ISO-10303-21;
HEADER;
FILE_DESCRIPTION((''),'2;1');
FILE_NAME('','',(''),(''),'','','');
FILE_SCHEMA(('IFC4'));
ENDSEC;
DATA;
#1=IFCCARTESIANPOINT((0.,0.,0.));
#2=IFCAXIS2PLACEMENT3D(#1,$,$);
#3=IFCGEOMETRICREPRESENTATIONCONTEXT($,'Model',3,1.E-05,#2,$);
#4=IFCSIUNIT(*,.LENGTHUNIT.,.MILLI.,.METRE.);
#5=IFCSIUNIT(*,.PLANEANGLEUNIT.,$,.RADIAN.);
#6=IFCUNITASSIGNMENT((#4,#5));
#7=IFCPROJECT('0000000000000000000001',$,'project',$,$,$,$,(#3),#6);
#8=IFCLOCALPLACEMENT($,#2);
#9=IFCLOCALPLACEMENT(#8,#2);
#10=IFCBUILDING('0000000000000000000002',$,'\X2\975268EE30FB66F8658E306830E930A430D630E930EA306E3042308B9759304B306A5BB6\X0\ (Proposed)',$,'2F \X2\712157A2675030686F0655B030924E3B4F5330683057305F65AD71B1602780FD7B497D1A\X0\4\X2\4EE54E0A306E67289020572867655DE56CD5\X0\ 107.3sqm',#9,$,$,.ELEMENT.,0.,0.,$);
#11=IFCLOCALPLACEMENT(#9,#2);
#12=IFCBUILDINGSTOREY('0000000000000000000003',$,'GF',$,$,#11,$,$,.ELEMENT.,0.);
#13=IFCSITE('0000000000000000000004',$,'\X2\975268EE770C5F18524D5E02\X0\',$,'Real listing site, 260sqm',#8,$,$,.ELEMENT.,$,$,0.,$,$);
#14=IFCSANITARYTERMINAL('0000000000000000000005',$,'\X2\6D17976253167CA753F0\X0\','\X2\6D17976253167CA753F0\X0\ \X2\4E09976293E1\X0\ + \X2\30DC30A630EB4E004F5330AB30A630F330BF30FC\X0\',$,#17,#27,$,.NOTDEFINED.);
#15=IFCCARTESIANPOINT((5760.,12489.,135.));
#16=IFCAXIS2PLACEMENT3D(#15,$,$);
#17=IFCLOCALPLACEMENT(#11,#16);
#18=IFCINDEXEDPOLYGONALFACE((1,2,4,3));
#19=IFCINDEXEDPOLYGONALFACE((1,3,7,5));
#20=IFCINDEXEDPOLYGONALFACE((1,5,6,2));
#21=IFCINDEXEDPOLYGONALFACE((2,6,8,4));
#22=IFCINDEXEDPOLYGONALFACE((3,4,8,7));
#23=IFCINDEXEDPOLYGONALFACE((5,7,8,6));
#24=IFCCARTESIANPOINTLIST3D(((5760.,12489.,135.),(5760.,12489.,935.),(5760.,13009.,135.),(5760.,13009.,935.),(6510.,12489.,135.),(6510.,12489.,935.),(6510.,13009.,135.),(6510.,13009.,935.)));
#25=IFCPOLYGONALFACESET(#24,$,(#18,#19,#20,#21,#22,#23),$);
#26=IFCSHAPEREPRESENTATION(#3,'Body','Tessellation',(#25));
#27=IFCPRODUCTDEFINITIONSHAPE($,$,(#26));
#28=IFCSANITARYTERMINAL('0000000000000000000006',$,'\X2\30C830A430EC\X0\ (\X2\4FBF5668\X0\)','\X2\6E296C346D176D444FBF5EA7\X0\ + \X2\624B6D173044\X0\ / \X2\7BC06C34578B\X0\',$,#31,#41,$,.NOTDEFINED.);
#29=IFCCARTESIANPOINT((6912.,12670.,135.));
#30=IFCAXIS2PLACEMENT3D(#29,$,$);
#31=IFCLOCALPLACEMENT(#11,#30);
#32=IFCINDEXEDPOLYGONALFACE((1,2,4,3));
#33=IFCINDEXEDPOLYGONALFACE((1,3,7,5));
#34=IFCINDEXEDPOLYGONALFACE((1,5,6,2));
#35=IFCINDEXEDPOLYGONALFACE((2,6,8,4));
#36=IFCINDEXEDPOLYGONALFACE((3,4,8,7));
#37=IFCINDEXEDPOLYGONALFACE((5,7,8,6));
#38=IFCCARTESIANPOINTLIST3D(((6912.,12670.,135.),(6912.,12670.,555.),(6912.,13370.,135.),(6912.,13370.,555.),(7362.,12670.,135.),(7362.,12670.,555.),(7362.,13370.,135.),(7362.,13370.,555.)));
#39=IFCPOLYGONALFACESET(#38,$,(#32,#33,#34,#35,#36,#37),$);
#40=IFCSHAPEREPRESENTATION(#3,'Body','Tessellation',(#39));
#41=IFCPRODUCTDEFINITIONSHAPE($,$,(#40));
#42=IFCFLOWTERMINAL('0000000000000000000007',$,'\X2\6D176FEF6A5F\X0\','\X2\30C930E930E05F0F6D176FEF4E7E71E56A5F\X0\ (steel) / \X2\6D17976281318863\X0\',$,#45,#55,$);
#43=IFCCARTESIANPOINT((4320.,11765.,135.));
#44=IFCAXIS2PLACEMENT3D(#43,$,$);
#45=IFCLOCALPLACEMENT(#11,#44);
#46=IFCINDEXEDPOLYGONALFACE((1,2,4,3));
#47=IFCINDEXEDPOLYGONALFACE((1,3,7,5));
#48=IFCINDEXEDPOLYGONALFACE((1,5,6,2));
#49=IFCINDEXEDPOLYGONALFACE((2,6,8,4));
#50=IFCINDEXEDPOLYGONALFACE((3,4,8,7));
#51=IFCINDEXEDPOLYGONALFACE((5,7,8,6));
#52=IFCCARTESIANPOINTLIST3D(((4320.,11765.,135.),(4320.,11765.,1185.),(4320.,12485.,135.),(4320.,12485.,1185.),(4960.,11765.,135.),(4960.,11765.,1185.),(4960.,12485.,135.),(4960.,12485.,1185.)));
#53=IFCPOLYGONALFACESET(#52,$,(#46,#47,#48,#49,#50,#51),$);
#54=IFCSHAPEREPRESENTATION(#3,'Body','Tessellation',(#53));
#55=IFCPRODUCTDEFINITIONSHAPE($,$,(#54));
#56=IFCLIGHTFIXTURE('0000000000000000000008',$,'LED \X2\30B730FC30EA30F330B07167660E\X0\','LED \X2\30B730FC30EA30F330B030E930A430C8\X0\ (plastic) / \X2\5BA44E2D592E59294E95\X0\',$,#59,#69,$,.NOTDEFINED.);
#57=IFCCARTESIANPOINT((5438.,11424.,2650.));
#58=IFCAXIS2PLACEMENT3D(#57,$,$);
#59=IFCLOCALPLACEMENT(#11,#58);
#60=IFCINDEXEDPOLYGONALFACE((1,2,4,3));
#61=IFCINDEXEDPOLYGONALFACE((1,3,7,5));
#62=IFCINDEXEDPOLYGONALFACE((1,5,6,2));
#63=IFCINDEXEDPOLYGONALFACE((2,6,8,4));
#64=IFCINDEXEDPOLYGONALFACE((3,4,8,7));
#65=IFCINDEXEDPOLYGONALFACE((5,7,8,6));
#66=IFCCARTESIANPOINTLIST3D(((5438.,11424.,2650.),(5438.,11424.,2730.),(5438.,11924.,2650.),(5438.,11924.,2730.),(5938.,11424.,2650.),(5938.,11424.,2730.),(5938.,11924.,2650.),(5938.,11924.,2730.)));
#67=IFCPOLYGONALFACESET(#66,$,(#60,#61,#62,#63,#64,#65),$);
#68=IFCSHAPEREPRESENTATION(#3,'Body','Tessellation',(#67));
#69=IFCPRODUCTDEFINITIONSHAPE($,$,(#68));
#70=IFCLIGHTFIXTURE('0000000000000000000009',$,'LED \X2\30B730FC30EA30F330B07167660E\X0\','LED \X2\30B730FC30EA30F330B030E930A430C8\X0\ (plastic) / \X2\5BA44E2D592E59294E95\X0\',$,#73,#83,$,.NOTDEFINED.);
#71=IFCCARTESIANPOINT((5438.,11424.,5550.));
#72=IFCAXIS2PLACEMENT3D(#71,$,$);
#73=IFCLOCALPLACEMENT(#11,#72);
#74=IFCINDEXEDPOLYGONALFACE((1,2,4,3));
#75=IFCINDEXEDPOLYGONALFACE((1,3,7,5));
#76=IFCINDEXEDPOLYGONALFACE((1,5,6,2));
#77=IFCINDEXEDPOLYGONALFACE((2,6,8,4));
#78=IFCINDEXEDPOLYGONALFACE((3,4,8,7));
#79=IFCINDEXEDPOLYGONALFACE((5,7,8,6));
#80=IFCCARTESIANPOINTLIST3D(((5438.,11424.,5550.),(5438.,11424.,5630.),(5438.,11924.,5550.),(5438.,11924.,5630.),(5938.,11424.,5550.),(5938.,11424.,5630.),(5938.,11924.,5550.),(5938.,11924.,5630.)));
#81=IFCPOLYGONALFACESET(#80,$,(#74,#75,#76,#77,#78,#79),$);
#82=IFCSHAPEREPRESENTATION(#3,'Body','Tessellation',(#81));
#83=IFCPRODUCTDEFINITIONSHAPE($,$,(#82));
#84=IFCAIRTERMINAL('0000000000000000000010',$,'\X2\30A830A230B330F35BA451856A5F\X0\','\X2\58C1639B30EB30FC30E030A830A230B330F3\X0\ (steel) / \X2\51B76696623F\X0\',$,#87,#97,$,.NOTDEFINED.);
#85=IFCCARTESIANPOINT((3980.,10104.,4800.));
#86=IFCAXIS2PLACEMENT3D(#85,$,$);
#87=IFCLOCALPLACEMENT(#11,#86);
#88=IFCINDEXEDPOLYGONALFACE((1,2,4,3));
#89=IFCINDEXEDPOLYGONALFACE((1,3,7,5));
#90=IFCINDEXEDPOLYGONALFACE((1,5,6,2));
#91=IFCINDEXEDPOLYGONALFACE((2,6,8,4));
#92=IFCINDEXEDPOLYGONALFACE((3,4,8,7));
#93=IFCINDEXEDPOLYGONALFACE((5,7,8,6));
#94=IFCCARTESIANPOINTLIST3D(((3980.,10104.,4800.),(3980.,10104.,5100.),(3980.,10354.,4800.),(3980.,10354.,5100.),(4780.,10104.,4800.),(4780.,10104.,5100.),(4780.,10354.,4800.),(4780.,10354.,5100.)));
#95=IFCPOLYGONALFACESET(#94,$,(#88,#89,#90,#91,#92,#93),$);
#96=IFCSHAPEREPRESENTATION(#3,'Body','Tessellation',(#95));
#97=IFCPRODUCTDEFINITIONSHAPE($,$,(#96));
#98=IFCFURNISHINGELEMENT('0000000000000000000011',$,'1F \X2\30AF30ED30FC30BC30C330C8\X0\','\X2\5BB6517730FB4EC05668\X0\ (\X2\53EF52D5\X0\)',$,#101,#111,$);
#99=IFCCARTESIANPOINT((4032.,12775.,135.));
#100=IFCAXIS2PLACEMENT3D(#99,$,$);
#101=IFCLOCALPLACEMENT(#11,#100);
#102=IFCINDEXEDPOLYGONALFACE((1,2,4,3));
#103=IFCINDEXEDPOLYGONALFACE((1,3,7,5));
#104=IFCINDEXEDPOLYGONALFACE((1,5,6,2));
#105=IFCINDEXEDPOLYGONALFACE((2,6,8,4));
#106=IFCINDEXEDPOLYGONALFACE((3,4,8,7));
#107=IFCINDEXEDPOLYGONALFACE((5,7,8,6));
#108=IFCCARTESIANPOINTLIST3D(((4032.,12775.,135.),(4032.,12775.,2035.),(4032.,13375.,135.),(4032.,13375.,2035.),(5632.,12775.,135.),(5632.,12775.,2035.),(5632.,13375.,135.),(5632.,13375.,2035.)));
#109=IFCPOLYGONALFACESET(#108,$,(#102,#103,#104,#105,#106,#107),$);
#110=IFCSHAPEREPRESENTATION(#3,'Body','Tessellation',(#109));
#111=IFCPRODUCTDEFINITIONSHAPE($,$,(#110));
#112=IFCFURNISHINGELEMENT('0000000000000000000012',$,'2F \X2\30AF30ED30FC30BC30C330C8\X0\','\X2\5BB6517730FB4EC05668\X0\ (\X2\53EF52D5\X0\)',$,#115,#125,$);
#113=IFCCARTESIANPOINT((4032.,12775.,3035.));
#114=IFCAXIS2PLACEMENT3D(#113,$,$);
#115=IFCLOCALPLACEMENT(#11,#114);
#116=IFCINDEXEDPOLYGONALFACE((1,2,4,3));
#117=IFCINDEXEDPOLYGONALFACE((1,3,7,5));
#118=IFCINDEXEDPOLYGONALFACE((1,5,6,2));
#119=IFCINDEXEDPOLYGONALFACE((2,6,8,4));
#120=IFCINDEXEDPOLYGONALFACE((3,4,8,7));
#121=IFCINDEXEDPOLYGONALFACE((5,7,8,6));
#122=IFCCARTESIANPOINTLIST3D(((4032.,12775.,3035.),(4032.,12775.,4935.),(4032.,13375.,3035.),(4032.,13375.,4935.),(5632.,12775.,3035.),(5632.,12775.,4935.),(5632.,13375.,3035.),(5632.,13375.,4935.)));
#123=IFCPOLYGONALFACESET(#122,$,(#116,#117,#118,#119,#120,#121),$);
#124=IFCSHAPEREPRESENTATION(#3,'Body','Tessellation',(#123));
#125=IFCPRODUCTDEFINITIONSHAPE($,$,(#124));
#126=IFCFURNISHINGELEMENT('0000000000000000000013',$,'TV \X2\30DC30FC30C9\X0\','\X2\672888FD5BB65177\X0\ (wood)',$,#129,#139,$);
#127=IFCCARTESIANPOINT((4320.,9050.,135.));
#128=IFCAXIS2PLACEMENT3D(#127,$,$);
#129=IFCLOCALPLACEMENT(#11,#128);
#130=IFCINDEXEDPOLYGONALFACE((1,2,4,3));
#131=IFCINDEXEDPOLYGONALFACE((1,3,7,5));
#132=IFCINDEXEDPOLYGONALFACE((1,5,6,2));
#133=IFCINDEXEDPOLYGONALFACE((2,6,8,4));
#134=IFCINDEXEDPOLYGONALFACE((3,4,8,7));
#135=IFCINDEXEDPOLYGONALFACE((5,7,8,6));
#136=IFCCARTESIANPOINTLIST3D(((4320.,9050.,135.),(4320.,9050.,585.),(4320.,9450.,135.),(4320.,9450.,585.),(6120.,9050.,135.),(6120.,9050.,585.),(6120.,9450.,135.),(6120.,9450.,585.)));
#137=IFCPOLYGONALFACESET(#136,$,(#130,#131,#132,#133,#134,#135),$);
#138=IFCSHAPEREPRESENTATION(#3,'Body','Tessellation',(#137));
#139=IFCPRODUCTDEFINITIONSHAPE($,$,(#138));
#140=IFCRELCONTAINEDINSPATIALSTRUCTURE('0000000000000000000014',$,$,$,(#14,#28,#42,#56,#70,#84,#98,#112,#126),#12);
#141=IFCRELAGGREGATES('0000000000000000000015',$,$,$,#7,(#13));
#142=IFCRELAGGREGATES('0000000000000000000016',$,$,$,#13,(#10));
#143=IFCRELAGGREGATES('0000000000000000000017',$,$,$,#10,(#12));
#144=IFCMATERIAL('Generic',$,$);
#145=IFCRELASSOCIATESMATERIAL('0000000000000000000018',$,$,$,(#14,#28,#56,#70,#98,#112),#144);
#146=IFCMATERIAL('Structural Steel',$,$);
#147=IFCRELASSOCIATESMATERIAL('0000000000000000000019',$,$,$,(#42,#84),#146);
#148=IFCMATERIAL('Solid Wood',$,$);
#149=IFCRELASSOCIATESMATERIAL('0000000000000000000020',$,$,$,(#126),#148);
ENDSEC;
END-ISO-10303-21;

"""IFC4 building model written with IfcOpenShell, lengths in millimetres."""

from ifc_helpers import new_model, si_unit, frame, frame_2d, origin, place, context, project, spatial, rectangle, extrude, material, element, save


model = new_model("IFC4")

# Units and contexts
model_context = context("Model", 3, precision=1e-05, world=origin())
ifc_project = project(units=[si_unit("LENGTHUNIT", "METRE", prefix="MILLI"), si_unit("PLANEANGLEUNIT", "RADIAN")], contexts=[model_context])

# Site, building, storey
site_placement = place(None, origin())
site = spatial("IfcSite", under=ifc_project, at=site_placement, Name="青森県弘前市", ObjectType="Real listing site, 260sqm", CompositionType="ELEMENT", RefElevation=0.0)
building_placement = place(site_placement, origin())
building = spatial("IfcBuilding", under=site, at=building_placement, Name="青森・書斎とライブラリのある静かな家 (Proposed)", ObjectType="2F 無垢材と漆喰を主体とした断熱性能等級4以上の木造在来工法 107.3sqm", CompositionType="ELEMENT", ElevationOfRefHeight=0.0, ElevationOfTerrain=0.0)
storey_placement = place(building_placement, origin())
storey = spatial("IfcBuildingStorey", under=building, at=storey_placement, Name="GF", CompositionType="ELEMENT", Elevation=0.0)

# Shared definitions
ifc_material_1 = material(Name="Solid Wood")

# Sanitary terminals
ifc_material_2 = material(Name="Generic")
sanitary_terminal_1_placement = place(storey_placement, frame((5760.0, 12489.0, 135.0)))
element("IfcSanitaryTerminal", 1, at=sanitary_terminal_1_placement, inside=storey, material=ifc_material_2, Name="洗面化粧台", Description="洗面化粧台 三面鏡 + ボウル一体カウンター", PredefinedType="NOTDEFINED", context=model_context, shape_type="SweptSolid", body=[
    extrude(rectangle(XDim=750.0, YDim=520.0, at=frame_2d((375.0, 260.0))), frame((5760.0, 12489.0, 135.0)), (0.0, 0.0, 1.0), 800.0),
])
sanitary_terminal_2_placement = place(storey_placement, frame((6912.0, 12670.0, 135.0)))
element("IfcSanitaryTerminal", 2, at=sanitary_terminal_2_placement, inside=storey, material=ifc_material_2, Name="トイレ (便器)", Description="温水洗浄便座 + 手洗い / 節水型", PredefinedType="NOTDEFINED", context=model_context, shape_type="SweptSolid", body=[
    extrude(rectangle(XDim=450.0, YDim=700.0, at=frame_2d((225.0, 350.0))), frame((6912.0, 12670.0, 135.0)), (0.0, 0.0, 1.0), 420.0),
])

# Flow terminal
ifc_material_3 = material(Name="Structural Steel")
flow_terminal_placement = place(storey_placement, frame((4320.0, 11765.0, 135.0)))
element("IfcFlowTerminal", 3, at=flow_terminal_placement, inside=storey, material=ifc_material_3, Name="洗濯機", Description="ドラム式洗濯乾燥機 (steel) / 洗面脱衣", context=model_context, shape_type="SweptSolid", body=[
    extrude(rectangle(XDim=640.0, YDim=720.0, at=frame_2d((320.0, 360.0))), frame((4320.0, 11765.0, 135.0)), (0.0, 0.0, 1.0), 1050.0),
])

# Light fixtures
light_fixture_1_placement = place(storey_placement, frame((5438.0, 11424.0, 2650.0)))
element("IfcLightFixture", 4, at=light_fixture_1_placement, inside=storey, material=ifc_material_2, Name="LED シーリング照明", Description="LED シーリングライト (plastic) / 室中央天井", PredefinedType="NOTDEFINED", context=model_context, shape_type="SweptSolid", body=[
    extrude(rectangle(XDim=500.0, YDim=500.0, at=frame_2d((250.0, 250.0))), frame((5438.0, 11424.0, 2650.0)), (0.0, 0.0, 1.0), 80.0),
])
light_fixture_2_placement = place(storey_placement, frame((5438.0, 11424.0, 5550.0)))
element("IfcLightFixture", 5, at=light_fixture_2_placement, inside=storey, material=ifc_material_2, Name="LED シーリング照明", Description="LED シーリングライト (plastic) / 室中央天井", PredefinedType="NOTDEFINED", context=model_context, shape_type="SweptSolid", body=[
    extrude(rectangle(XDim=500.0, YDim=500.0, at=frame_2d((250.0, 250.0))), frame((5438.0, 11424.0, 5550.0)), (0.0, 0.0, 1.0), 80.0),
])

# Air terminal
air_terminal_placement = place(storey_placement, frame((3980.0, 10104.0, 4800.0)))
element("IfcAirTerminal", 6, at=air_terminal_placement, inside=storey, material=ifc_material_3, Name="エアコン室内機", Description="壁掛ルームエアコン (steel) / 冷暖房", PredefinedType="NOTDEFINED", context=model_context, shape_type="SweptSolid", body=[
    extrude(rectangle(XDim=800.0, YDim=250.0, at=frame_2d((400.0, 125.0))), frame((3980.0, 10104.0, 4800.0)), (0.0, 0.0, 1.0), 300.0),
])

# Furnishing elements
furnishing_1_placement = place(storey_placement, frame((4032.0, 12775.0, 135.0)))
element("IfcFurnishingElement", 7, at=furnishing_1_placement, inside=storey, material=ifc_material_2, Name="1F クローゼット", Description="家具・什器 (可動)", context=model_context, shape_type="SweptSolid", body=[
    extrude(rectangle(XDim=1600.0, YDim=600.0, at=frame_2d((800.0, 300.0))), frame((4032.0, 12775.0, 135.0)), (0.0, 0.0, 1.0), 1900.0),
])
furnishing_2_placement = place(storey_placement, frame((4032.0, 12775.0, 3035.0)))
element("IfcFurnishingElement", 8, at=furnishing_2_placement, inside=storey, material=ifc_material_2, Name="2F クローゼット", Description="家具・什器 (可動)", context=model_context, shape_type="SweptSolid", body=[
    extrude(rectangle(XDim=1600.0, YDim=600.0, at=frame_2d((800.0, 300.0))), frame((4032.0, 12775.0, 3035.0)), (0.0, 0.0, 1.0), 1900.0),
])
furnishing_3_placement = place(storey_placement, frame((4320.0, 9050.0, 135.0)))
element("IfcFurnishingElement", 9, at=furnishing_3_placement, inside=storey, material=ifc_material_1, Name="TV ボード", Description="木製家具 (wood)", context=model_context, shape_type="SweptSolid", body=[
    extrude(rectangle(XDim=1800.0, YDim=400.0, at=frame_2d((900.0, 200.0))), frame((4320.0, 9050.0, 135.0)), (0.0, 0.0, 1.0), 450.0),
])

save(model, "model.ifc")
